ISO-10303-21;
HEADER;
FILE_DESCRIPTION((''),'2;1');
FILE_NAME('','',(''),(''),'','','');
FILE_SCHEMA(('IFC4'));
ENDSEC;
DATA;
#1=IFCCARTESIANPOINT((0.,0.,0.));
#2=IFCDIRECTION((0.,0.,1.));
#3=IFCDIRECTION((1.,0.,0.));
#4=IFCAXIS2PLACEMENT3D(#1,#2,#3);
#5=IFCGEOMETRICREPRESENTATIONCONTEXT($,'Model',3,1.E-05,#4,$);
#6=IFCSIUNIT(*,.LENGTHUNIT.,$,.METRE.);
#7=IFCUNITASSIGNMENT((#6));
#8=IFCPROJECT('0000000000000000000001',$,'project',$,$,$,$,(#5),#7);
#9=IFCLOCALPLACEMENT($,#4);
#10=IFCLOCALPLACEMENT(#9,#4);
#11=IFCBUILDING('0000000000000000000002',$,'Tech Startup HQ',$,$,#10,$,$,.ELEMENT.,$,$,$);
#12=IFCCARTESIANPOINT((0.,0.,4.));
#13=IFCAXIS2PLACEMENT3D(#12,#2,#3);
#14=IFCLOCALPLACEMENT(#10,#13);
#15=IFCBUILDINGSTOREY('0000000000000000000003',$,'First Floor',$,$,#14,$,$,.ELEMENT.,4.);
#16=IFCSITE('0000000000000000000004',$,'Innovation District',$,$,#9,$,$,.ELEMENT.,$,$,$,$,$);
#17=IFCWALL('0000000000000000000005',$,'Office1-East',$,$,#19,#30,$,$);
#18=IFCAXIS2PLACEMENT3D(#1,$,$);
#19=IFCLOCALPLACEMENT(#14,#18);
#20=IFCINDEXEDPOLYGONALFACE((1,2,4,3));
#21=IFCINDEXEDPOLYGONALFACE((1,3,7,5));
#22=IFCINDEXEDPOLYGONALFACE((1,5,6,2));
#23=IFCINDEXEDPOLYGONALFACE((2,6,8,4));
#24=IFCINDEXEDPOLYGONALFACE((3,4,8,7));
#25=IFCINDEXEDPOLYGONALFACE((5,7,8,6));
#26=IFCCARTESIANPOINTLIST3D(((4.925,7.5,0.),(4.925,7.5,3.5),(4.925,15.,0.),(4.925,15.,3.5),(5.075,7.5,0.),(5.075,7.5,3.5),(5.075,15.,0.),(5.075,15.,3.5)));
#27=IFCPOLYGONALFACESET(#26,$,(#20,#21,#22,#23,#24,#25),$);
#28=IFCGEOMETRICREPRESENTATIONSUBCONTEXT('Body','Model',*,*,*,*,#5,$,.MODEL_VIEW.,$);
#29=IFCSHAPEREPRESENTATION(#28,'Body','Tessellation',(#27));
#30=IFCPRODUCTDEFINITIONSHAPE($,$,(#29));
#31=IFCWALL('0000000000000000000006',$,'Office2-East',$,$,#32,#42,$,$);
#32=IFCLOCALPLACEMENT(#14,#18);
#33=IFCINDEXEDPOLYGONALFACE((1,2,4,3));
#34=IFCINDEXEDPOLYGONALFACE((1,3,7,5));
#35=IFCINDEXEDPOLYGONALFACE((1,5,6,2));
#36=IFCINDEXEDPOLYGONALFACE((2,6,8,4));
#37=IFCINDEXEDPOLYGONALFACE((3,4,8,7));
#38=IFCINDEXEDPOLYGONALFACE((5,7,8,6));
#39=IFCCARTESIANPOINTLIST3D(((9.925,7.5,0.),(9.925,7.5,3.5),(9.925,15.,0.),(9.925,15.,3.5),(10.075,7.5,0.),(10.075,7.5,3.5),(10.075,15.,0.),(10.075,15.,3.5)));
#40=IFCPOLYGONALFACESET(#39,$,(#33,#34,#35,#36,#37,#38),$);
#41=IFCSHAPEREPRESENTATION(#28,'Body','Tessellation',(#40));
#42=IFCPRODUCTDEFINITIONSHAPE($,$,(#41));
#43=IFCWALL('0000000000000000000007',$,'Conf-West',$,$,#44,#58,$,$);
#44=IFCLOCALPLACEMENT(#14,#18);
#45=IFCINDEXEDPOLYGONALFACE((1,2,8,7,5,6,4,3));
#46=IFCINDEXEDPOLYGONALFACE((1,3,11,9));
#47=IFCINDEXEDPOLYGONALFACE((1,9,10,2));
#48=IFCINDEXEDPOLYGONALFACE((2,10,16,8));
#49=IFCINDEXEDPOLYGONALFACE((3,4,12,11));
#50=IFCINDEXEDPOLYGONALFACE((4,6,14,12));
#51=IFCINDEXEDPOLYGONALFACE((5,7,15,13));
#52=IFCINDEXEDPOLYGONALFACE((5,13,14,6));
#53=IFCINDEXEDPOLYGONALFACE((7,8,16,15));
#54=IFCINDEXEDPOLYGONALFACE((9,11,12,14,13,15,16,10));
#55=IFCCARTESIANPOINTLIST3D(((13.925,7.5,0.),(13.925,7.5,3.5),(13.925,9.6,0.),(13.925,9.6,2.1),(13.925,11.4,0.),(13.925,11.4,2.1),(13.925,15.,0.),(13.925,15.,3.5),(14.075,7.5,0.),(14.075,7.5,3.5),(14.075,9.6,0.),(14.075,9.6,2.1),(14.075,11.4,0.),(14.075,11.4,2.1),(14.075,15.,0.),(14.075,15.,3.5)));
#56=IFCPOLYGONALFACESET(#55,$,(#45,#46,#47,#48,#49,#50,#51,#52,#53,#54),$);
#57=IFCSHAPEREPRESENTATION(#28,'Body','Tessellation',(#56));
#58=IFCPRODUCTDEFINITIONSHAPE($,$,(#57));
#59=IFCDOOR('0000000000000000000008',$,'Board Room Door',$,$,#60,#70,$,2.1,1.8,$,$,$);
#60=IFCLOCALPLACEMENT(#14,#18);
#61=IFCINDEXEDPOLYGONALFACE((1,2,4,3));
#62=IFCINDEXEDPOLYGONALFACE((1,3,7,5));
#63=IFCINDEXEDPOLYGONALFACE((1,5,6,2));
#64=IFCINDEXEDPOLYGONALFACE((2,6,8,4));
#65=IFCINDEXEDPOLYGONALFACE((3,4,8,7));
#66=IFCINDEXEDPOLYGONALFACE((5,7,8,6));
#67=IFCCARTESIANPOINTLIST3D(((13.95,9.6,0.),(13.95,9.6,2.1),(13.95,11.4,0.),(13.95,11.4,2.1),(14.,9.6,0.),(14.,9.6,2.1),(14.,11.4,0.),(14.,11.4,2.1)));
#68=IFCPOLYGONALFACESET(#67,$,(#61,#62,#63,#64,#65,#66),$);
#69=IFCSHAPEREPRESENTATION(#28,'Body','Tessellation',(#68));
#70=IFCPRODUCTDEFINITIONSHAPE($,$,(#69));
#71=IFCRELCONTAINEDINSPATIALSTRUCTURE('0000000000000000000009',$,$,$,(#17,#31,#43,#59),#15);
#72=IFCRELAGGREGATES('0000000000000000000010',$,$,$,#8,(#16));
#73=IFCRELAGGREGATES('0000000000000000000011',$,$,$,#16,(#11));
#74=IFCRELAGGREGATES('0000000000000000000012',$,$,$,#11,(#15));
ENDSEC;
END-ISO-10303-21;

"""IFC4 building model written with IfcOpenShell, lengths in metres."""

from ifc_helpers import new_model, si_unit, frame, origin_with_axes, place, context, subcontext, project, spatial, polyline, outline, extrude, element, fill, save


model = new_model("IFC4")

# Units and contexts
model_context = context("Model", 3, precision=1e-05, world=origin_with_axes())
body_context = subcontext(model_context, "Body", "Model", "MODEL_VIEW")
ifc_project = project(units=[si_unit("LENGTHUNIT", "METRE")], contexts=[model_context])

# Site, building, storey
site_placement = place(None, origin_with_axes())
site = spatial("IfcSite", under=ifc_project, at=site_placement, Name="Innovation District", CompositionType="ELEMENT")
building_placement = place(site_placement, origin_with_axes())
building = spatial("IfcBuilding", under=site, at=building_placement, Name="Tech Startup HQ", CompositionType="ELEMENT")
storey_placement = place(building_placement, frame((0.0, 0.0, 4.0), z_axis=(0.0, 0.0, 1.0), x_axis=(1.0, 0.0, 0.0)))
storey = spatial("IfcBuildingStorey", under=building, at=storey_placement, Name="First Floor", CompositionType="ELEMENT", Elevation=4.0)

# Walls
wall_1_placement = place(storey_placement, origin_with_axes())
element("IfcWall", 1, at=wall_1_placement, inside=storey, Name="Office1-East", context=body_context, shape_type="SweptSolid", body=[
    extrude(outline(polyline([(5.075, 7.5, 0.0), (5.075, 15.0, 0.0), (4.925, 15.0, 0.0), (4.925, 7.5, 0.0), (5.075, 7.5, 0.0)])), None, (0.0, 0.0, 1.0), 3.5),
])
wall_2_placement = place(storey_placement, origin_with_axes())
element("IfcWall", 2, at=wall_2_placement, inside=storey, Name="Office2-East", context=body_context, shape_type="SweptSolid", body=[
    extrude(outline(polyline([(10.075, 7.5, 0.0), (10.075, 15.0, 0.0), (9.925, 15.0, 0.0), (9.925, 7.5, 0.0), (10.075, 7.5, 0.0)])), None, (0.0, 0.0, 1.0), 3.5),
])

# Wall, opening, door
wall_3_placement = place(storey_placement, origin_with_axes())
wall_3 = element("IfcWall", 3, at=wall_3_placement, inside=storey, Name="Conf-West", context=body_context, shape_type="SweptSolid", body=[
    extrude(outline(polyline([(14.075, 7.5, 0.0), (14.075, 15.0, 0.0), (13.925, 15.0, 0.0), (13.925, 7.5, 0.0), (14.075, 7.5, 0.0)])), None, (0.0, 0.0, 1.0), 3.5),
])
opening_1_placement = place(storey_placement, origin_with_axes())
opening_1 = element("IfcOpeningElement", 4, at=opening_1_placement, inside=storey, cuts=wall_3, context=body_context, shape_type="SweptSolid", body=[
    extrude(outline(polyline([(14.15, 9.6, 0.0), (14.15, 11.4, 0.0), (13.85, 11.4, 0.0), (13.85, 9.6, 0.0), (14.15, 9.6, 0.0)])), None, (0.0, 0.0, 1.0), 2.1),
])
door_1_placement = place(storey_placement, origin_with_axes())
door_1 = element("IfcDoor", 5, at=door_1_placement, inside=storey, Name="Board Room Door", OverallHeight=2.1, OverallWidth=1.8, context=body_context, shape_type="SweptSolid", body=[
    extrude(outline(polyline([(14.0, 9.6, 0.0), (14.0, 11.4, 0.0), (13.95, 11.4, 0.0), (13.95, 9.6, 0.0), (14.0, 9.6, 0.0)])), None, (0.0, 0.0, 1.0), 2.1),
])
fill(opening_1, door_1)

save(model, "model.ifc")
